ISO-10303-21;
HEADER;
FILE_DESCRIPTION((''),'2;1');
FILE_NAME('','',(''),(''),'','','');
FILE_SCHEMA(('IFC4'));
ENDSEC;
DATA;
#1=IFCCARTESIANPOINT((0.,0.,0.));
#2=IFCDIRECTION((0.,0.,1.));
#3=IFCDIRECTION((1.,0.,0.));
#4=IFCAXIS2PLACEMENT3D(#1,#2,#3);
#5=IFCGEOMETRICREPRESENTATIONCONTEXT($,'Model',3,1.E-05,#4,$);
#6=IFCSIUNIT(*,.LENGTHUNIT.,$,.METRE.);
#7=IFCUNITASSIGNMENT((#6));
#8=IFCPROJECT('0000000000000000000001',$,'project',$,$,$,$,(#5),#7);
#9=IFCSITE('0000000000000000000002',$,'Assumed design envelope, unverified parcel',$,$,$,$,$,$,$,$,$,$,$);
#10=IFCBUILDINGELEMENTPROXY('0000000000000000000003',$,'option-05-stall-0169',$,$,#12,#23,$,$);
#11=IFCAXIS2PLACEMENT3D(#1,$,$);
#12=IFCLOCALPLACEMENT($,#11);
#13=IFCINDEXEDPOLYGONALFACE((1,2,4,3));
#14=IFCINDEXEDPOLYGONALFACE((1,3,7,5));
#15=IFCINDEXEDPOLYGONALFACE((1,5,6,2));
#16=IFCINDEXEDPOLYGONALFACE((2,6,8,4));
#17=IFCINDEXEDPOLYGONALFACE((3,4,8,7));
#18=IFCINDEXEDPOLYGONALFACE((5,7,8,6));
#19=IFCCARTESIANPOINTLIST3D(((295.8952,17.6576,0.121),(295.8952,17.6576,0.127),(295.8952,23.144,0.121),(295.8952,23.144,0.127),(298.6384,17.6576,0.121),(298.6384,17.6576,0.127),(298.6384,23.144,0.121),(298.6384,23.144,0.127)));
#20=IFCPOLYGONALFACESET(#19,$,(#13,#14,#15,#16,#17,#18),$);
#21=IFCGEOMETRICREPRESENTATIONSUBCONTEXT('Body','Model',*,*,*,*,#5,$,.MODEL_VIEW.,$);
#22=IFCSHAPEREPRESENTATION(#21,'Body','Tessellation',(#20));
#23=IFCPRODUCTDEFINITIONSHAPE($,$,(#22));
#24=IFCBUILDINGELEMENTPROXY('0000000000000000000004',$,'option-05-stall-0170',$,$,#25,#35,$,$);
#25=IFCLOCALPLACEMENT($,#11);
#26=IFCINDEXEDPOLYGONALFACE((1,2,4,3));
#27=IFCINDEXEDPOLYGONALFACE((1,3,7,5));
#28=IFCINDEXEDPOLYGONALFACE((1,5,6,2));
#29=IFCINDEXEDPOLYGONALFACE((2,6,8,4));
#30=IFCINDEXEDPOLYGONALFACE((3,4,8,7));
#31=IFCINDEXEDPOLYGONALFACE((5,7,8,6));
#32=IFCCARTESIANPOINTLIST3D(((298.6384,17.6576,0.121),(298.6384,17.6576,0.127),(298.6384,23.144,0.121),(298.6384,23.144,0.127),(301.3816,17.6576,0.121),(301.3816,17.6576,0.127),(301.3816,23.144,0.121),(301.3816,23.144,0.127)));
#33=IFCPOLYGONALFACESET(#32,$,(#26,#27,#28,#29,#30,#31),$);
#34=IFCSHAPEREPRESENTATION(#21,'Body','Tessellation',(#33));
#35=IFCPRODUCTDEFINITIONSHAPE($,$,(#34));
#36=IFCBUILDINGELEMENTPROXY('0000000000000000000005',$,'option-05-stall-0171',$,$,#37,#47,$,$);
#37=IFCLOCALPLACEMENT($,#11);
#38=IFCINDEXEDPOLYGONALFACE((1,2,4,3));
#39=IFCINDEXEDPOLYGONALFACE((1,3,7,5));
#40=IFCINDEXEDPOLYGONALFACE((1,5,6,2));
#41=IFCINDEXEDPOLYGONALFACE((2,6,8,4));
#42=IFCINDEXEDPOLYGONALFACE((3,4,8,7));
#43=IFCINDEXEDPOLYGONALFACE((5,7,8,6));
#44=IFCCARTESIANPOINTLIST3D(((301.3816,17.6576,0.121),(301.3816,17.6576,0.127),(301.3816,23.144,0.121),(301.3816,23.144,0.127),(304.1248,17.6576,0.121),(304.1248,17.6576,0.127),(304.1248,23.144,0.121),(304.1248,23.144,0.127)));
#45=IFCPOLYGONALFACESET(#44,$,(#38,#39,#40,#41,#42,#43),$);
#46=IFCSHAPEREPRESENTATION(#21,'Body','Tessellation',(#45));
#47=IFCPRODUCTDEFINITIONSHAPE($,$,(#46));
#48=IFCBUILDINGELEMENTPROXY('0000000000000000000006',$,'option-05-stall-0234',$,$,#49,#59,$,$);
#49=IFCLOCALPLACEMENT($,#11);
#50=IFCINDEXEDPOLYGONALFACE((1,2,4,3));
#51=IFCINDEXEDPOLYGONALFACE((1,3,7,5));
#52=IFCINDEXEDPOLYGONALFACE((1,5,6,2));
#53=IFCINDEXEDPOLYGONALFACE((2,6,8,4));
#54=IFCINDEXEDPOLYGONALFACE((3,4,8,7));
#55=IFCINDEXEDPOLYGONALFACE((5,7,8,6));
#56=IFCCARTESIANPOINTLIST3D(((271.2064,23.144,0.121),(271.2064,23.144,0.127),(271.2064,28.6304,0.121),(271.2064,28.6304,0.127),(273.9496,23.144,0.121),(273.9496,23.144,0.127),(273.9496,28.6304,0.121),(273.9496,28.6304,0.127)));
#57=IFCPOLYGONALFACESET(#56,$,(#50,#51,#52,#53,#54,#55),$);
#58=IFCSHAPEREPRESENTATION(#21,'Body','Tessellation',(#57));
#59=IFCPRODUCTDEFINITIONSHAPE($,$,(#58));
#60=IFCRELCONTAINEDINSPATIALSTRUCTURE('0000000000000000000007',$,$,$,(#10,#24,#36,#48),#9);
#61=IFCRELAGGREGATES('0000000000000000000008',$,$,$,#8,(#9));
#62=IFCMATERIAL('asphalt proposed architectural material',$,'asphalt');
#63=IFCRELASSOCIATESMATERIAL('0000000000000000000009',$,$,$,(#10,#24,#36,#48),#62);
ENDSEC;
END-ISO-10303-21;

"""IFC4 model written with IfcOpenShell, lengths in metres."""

from ifc_helpers import new_model, si_unit, frame, origin_with_axes, place, context, subcontext, project, spatial, rectangle, extrude, material, element, save


model = new_model("IFC4")

# Units and contexts
model_context = context("Model", 3, precision=1e-05, world=origin_with_axes())
body_context = subcontext(model_context, "Body", "Model", "MODEL_VIEW")
ifc_project = project(units=[si_unit("LENGTHUNIT", "METRE")], contexts=[model_context])

# Site
site = spatial("IfcSite", under=ifc_project, Name="Assumed design envelope, unverified parcel")

# Building element proxies
ifc_material = material(Name="asphalt proposed architectural material", Category="asphalt")
for number, where, z_axis, x_axis, name in (
    (1, (297.2668, 20.4008, 0.121), (0.0, 0.0, 1.0), (1.0, 0.0, 0.0), "option-05-stall-0169"),
    (2, (300.01, 20.4008, 0.121), (0.0, 0.0, 1.0), (1.0, 0.0, 0.0), "option-05-stall-0170"),
    (3, (302.7532, 20.4008, 0.121), (0.0, 0.0, 1.0), (1.0, 0.0, 0.0), "option-05-stall-0171"),
    (4, (272.578, 25.8872, 0.121), (0.0, 0.0, 1.0), (1.0, 0.0, 0.0), "option-05-stall-0234"),
):
    element("IfcBuildingElementProxy", number, at=place(None, frame(where, z_axis=z_axis, x_axis=x_axis)), inside=site, material=ifc_material, Name=name, context=body_context, shape_type="SweptSolid", body=[
        extrude(rectangle(XDim=2.7432, YDim=5.4864), origin_with_axes(), (0.0, 0.0, 1.0), 0.006),
    ])

save(model, "model.ifc")
